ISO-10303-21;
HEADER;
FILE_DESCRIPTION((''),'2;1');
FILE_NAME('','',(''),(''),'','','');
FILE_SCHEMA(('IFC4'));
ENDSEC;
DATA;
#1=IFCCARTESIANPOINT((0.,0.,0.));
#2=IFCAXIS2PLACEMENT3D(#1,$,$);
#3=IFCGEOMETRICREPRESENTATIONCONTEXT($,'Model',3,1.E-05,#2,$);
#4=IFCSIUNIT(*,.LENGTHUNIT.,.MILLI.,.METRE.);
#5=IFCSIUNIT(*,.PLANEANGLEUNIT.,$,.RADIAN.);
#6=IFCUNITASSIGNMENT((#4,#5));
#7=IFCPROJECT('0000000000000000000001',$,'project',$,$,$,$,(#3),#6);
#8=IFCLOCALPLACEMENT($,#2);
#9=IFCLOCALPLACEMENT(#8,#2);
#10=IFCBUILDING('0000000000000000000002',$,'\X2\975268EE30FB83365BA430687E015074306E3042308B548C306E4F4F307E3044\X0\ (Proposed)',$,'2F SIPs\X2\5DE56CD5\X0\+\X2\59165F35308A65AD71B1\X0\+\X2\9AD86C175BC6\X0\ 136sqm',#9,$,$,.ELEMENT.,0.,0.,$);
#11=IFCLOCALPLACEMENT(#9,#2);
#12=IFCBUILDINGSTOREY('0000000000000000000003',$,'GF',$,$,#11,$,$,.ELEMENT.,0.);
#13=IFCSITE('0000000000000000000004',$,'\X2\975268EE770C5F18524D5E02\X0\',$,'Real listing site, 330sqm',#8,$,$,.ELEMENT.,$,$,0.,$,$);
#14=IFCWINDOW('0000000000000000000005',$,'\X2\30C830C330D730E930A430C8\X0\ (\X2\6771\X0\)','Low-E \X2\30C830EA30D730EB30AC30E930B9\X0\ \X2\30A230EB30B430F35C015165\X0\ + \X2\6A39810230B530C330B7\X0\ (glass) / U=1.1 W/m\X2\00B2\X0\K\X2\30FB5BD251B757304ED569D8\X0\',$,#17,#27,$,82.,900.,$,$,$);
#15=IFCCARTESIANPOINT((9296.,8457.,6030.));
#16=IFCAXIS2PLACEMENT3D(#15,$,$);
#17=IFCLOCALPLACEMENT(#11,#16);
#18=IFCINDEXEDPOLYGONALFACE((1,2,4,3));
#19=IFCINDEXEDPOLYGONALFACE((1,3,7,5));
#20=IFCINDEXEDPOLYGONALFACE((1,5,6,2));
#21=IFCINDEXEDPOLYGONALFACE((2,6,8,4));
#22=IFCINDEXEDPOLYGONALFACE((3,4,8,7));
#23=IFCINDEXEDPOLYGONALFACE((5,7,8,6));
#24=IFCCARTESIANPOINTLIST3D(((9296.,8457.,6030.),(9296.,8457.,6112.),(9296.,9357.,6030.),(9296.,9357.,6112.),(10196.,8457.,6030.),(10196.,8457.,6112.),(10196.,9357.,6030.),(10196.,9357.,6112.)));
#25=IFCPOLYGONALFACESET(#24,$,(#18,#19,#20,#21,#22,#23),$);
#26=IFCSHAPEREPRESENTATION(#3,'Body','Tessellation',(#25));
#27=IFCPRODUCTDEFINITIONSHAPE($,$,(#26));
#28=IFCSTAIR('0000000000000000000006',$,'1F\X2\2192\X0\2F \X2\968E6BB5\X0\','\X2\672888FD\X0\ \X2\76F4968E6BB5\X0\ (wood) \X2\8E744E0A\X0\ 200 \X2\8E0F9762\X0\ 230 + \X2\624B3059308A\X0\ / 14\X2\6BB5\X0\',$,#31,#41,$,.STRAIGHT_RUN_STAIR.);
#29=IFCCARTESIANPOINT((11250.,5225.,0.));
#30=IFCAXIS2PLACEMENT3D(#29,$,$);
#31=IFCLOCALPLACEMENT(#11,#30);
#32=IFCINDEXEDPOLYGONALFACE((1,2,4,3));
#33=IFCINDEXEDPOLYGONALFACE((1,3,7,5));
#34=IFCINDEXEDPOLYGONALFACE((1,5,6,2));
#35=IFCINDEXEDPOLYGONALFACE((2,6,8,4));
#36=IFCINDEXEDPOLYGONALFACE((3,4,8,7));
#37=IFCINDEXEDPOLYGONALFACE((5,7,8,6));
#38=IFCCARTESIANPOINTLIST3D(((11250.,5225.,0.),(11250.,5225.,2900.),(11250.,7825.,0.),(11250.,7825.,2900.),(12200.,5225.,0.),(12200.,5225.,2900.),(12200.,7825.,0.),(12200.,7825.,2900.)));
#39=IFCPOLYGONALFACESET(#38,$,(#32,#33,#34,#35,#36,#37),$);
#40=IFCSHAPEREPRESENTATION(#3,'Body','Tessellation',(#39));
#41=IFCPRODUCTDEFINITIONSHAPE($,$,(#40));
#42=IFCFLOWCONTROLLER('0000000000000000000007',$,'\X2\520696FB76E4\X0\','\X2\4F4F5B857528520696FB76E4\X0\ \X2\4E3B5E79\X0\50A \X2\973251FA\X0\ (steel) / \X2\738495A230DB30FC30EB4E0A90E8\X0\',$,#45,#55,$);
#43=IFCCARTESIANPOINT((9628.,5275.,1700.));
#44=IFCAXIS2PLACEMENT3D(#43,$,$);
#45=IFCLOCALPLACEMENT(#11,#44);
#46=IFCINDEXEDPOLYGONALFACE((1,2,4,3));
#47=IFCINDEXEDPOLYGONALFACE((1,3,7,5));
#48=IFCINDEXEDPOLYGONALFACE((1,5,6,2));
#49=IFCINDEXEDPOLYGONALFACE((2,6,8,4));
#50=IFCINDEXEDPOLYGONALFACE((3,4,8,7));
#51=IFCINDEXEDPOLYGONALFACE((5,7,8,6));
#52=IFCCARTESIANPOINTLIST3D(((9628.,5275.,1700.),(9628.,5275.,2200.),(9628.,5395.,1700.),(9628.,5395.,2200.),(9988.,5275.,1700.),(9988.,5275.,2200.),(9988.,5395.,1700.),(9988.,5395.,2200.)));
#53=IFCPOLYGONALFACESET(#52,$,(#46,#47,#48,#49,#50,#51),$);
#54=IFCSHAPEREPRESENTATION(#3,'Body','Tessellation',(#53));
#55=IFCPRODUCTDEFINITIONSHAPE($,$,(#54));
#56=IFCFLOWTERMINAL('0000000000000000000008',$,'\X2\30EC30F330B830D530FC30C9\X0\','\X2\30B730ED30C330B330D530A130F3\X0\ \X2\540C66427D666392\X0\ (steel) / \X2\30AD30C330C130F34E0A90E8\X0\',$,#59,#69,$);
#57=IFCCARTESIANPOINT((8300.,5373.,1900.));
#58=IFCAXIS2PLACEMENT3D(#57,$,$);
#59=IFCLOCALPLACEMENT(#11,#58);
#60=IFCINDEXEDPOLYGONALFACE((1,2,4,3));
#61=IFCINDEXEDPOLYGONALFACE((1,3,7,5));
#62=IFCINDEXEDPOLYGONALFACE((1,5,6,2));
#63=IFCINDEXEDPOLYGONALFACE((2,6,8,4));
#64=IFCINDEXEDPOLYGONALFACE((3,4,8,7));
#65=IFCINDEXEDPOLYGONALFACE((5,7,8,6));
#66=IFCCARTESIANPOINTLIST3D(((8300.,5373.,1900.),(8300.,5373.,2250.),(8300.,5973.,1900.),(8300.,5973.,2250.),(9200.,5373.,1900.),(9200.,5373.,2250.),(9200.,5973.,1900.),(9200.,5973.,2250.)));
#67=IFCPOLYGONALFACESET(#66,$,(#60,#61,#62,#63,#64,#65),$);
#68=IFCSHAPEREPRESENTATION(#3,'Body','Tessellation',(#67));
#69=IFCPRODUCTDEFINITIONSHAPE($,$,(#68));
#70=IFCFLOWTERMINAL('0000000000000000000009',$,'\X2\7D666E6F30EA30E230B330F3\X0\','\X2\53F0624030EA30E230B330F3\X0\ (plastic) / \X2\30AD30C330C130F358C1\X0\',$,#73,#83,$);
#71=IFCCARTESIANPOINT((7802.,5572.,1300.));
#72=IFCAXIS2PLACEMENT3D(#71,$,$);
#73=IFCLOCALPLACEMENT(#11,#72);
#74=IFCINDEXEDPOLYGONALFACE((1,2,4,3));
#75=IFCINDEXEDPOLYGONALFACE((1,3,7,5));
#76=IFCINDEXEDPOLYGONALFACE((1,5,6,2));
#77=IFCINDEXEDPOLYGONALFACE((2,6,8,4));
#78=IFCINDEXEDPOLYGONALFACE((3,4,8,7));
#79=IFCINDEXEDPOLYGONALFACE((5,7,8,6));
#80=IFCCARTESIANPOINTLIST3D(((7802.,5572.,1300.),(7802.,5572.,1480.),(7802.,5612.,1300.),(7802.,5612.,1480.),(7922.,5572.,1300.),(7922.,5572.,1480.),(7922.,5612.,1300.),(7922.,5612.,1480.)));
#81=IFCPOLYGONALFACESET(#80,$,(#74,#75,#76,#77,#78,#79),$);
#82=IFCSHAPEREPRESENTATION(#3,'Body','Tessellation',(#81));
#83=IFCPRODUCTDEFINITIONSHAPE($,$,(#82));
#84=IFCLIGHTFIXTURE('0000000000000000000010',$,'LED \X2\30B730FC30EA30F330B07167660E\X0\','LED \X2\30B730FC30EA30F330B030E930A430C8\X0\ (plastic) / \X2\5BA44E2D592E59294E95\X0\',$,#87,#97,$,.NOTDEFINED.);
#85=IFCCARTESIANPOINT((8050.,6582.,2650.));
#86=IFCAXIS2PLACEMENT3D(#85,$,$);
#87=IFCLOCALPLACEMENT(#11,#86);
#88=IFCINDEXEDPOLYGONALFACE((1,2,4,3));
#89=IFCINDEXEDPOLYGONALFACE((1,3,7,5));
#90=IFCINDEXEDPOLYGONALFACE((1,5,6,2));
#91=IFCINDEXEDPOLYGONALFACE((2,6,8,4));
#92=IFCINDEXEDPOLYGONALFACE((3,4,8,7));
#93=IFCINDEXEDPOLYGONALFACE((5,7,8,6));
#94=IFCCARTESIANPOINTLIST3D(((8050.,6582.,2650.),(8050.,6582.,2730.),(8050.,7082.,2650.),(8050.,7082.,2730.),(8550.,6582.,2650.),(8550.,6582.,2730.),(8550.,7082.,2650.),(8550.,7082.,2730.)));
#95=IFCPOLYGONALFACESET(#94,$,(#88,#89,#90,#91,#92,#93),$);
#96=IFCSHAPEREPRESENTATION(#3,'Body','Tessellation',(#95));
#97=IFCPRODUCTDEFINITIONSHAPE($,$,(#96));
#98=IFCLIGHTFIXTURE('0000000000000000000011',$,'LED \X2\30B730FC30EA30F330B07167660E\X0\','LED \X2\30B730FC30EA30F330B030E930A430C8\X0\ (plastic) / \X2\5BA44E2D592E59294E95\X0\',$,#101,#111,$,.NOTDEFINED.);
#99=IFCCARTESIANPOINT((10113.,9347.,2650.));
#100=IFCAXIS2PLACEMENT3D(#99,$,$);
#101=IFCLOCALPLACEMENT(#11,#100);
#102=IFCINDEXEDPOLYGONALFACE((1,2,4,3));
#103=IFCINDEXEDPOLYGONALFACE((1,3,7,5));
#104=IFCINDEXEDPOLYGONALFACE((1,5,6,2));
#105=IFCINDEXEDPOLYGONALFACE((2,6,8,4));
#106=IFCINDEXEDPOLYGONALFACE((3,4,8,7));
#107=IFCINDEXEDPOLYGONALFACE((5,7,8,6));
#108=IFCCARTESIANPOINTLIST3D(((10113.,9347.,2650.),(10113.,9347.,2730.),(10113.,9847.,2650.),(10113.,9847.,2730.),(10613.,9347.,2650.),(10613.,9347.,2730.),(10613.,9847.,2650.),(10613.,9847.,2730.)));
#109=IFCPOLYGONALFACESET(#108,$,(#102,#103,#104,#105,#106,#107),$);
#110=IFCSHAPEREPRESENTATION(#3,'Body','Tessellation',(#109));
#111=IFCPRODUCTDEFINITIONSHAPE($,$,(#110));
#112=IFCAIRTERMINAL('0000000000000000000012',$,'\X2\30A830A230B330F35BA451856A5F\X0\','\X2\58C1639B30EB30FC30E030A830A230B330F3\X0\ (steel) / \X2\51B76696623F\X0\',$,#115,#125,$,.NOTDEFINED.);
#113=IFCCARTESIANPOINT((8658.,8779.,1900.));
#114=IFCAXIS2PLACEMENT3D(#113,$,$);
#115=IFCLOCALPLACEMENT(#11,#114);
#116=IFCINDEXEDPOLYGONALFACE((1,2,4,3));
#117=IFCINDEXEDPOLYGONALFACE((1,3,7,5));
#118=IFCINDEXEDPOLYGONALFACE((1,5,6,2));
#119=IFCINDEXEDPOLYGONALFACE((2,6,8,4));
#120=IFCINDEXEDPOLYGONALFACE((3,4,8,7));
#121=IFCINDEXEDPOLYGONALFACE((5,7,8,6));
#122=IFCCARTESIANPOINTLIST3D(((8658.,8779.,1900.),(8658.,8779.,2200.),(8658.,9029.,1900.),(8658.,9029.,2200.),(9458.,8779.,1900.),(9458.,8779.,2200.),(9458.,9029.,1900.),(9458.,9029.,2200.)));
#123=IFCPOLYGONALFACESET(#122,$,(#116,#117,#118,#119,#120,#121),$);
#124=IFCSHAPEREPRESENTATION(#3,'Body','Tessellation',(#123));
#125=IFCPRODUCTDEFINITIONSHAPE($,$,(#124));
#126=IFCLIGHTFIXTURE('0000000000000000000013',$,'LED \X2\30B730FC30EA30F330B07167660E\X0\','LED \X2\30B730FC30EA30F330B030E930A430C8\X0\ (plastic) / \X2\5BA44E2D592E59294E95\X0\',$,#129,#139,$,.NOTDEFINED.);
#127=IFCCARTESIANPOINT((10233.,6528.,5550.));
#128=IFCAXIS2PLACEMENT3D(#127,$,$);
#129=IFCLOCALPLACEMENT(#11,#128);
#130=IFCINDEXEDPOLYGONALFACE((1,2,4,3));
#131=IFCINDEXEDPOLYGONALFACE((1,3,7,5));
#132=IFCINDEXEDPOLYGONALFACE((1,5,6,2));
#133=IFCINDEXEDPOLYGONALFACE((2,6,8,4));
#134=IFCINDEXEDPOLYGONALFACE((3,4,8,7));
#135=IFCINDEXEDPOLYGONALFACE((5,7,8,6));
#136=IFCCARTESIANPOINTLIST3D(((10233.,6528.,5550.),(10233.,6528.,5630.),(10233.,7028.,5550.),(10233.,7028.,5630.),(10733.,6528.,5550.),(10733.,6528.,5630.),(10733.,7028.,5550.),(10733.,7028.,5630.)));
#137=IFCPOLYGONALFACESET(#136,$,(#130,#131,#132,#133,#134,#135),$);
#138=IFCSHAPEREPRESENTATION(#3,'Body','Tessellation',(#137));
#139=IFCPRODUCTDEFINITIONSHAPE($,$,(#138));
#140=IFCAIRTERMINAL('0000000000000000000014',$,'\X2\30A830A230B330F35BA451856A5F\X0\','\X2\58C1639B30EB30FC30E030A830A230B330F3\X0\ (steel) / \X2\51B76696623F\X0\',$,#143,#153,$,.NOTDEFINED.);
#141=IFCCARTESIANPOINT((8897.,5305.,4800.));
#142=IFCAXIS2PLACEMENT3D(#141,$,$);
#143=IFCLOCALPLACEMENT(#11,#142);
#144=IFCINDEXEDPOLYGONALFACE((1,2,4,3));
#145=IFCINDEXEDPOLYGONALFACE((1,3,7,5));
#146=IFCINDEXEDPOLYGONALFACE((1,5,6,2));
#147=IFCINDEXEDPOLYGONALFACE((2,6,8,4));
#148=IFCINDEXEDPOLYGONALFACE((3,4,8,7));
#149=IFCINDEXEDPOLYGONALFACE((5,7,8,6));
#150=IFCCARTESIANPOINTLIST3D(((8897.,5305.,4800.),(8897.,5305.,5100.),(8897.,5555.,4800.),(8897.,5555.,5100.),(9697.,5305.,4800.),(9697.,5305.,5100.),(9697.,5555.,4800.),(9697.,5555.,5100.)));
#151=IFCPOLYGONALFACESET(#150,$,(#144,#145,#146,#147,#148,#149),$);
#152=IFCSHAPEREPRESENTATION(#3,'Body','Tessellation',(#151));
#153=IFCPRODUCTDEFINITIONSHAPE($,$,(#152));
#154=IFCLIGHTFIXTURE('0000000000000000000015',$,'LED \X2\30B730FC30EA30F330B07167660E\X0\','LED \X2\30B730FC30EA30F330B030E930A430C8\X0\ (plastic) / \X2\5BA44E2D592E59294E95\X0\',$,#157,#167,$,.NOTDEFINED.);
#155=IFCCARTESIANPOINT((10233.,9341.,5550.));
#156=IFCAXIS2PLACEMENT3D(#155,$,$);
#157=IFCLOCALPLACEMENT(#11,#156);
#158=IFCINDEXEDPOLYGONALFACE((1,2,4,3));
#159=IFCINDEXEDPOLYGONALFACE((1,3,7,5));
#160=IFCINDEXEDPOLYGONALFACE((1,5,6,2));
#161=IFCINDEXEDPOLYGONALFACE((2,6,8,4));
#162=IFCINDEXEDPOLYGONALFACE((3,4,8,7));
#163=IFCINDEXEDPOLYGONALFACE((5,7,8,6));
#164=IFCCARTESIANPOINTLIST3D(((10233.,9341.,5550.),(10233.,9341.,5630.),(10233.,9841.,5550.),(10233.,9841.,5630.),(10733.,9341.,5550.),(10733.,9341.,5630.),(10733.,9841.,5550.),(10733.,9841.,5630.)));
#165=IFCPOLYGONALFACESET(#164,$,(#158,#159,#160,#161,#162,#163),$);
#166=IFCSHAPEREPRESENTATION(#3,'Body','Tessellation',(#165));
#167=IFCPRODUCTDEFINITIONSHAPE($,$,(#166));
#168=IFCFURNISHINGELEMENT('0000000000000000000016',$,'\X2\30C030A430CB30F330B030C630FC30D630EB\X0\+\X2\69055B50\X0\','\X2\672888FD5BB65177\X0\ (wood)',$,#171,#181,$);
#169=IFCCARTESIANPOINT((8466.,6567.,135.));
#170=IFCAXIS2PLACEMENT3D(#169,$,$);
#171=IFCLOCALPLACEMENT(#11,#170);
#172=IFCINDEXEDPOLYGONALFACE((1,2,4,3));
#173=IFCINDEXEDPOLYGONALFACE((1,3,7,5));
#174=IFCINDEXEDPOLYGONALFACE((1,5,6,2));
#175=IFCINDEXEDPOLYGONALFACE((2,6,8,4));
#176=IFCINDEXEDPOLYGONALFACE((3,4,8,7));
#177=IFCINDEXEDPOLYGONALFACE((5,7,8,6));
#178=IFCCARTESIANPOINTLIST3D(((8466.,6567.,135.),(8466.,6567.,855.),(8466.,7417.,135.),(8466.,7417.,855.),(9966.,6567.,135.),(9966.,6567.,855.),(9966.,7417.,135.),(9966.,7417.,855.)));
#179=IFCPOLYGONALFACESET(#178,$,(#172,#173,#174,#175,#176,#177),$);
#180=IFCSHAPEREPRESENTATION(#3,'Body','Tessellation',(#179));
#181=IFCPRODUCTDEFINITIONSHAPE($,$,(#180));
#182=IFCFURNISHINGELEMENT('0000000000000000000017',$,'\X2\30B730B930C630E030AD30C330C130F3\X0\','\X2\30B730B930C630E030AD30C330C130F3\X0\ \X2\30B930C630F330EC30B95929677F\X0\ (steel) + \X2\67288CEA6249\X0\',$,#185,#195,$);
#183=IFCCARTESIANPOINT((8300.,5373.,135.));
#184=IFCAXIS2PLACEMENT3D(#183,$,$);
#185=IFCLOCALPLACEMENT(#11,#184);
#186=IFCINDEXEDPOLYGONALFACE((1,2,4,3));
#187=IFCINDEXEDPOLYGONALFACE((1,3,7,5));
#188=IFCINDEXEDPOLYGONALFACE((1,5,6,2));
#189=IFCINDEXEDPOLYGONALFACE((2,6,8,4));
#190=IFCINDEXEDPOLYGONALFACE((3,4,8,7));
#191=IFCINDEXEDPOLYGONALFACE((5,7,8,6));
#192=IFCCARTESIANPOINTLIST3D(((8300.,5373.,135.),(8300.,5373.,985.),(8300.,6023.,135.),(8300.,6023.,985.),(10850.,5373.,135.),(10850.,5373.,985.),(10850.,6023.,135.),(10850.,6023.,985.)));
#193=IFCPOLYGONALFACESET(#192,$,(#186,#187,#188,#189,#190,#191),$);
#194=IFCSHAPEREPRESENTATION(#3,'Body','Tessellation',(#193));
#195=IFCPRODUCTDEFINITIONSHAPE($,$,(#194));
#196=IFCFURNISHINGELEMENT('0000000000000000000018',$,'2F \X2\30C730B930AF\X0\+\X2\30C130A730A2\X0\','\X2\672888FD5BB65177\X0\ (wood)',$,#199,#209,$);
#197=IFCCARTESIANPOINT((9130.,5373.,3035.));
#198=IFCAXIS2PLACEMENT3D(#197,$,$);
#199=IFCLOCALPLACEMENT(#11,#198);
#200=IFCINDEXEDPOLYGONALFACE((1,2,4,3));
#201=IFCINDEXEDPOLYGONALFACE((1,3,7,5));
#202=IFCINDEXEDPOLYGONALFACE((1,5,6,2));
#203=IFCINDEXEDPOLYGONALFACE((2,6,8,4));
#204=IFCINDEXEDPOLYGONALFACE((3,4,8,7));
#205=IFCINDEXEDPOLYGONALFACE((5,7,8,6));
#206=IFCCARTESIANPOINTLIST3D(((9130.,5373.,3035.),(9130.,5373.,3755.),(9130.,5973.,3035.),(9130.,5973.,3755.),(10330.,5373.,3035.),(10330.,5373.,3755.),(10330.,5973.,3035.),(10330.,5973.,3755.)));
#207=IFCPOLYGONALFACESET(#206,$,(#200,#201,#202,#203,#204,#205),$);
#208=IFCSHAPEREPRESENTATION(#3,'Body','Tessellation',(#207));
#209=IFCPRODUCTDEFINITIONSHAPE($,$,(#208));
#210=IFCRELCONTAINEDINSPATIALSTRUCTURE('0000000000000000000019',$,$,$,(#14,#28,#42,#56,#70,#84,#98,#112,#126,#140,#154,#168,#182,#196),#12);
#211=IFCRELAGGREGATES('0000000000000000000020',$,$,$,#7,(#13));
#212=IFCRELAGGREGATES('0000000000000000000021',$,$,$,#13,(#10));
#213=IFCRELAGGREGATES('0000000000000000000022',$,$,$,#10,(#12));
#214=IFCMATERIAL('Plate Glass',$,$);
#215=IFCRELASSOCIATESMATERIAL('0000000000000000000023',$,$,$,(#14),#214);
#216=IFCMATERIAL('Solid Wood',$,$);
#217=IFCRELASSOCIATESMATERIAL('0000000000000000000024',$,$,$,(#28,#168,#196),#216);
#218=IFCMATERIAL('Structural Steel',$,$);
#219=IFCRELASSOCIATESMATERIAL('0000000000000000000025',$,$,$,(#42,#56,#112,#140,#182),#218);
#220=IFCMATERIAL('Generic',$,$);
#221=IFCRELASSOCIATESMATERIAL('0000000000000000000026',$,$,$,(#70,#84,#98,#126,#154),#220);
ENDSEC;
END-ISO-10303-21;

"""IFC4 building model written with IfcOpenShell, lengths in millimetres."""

from ifc_helpers import new_model, si_unit, frame, frame_2d, origin, place, context, project, spatial, rectangle, extrude, material, element, save


model = new_model("IFC4")

# Units and contexts
model_context = context("Model", 3, precision=1e-05, world=origin())
ifc_project = project(units=[si_unit("LENGTHUNIT", "METRE", prefix="MILLI"), si_unit("PLANEANGLEUNIT", "RADIAN")], contexts=[model_context])

# Site, building, storey
site_placement = place(None, origin())
site = spatial("IfcSite", under=ifc_project, at=site_placement, Name="青森県弘前市", ObjectType="Real listing site, 330sqm", CompositionType="ELEMENT", RefElevation=0.0)
building_placement = place(site_placement, origin())
building = spatial("IfcBuilding", under=site, at=building_placement, Name="青森・茶室と縁側のある和の住まい (Proposed)", ObjectType="2F SIPs工法+外張り断熱+高気密 136sqm", CompositionType="ELEMENT", ElevationOfRefHeight=0.0, ElevationOfTerrain=0.0)
storey_placement = place(building_placement, origin())
storey = spatial("IfcBuildingStorey", under=building, at=storey_placement, Name="GF", CompositionType="ELEMENT", Elevation=0.0)

# Shared definitions
ifc_material_1 = material(Name="Solid Wood")

# Window
ifc_material_2 = material(Name="Plate Glass")
window_placement = place(storey_placement, frame((9296.0, 8457.0, 6030.0)))
element("IfcWindow", 1, at=window_placement, inside=storey, material=ifc_material_2, Name="トップライト (東)", Description="Low-E トリプルガラス アルゴン封入 + 樹脂サッシ (glass) / U=1.1 W/m²K・寒冷地仕様", OverallHeight=82.0, OverallWidth=900.0, context=model_context, shape_type="SweptSolid", body=[
    extrude(rectangle(XDim=900.0, YDim=900.0, at=frame_2d((450.0, 450.0))), frame((9296.0, 8457.0, 6030.0)), (0.0, 0.0, 1.0), 82.0),
])

# Stair
stair_placement = place(storey_placement, frame((11250.0, 5225.0, 0.0)))
element("IfcStair", 2, at=stair_placement, inside=storey, material=ifc_material_1, Name="1F→2F 階段", Description="木製 直階段 (wood) 蹴上 200 踏面 230 + 手すり / 14段", PredefinedType="STRAIGHT_RUN_STAIR", context=model_context, shape_type="SweptSolid", body=[
    extrude(rectangle(XDim=950.0, YDim=2600.0, at=frame_2d((475.0, 1300.0))), frame((11250.0, 5225.0, 0.0)), (0.0, 0.0, 1.0), 2900.0),
])

# Flow controller
ifc_material_3 = material(Name="Structural Steel")
flow_controller_placement = place(storey_placement, frame((9628.0, 5275.0, 1700.0)))
element("IfcFlowController", 3, at=flow_controller_placement, inside=storey, material=ifc_material_3, Name="分電盤", Description="住宅用分電盤 主幹50A 露出 (steel) / 玄関ホール上部", context=model_context, shape_type="SweptSolid", body=[
    extrude(rectangle(XDim=360.0, YDim=120.0, at=frame_2d((180.0, 60.0))), frame((9628.0, 5275.0, 1700.0)), (0.0, 0.0, 1.0), 500.0),
])

# Flow terminals
flow_terminal_1_placement = place(storey_placement, frame((8300.0, 5373.0, 1900.0)))
element("IfcFlowTerminal", 4, at=flow_terminal_1_placement, inside=storey, material=ifc_material_3, Name="レンジフード", Description="シロッコファン 同時給排 (steel) / キッチン上部", context=model_context, shape_type="SweptSolid", body=[
    extrude(rectangle(XDim=900.0, YDim=600.0, at=frame_2d((450.0, 300.0))), frame((8300.0, 5373.0, 1900.0)), (0.0, 0.0, 1.0), 350.0),
])
ifc_material_4 = material(Name="Generic")
flow_terminal_2_placement = place(storey_placement, frame((7802.0, 5572.0, 1300.0)))
element("IfcFlowTerminal", 5, at=flow_terminal_2_placement, inside=storey, material=ifc_material_4, Name="給湯リモコン", Description="台所リモコン (plastic) / キッチン壁", context=model_context, shape_type="SweptSolid", body=[
    extrude(rectangle(XDim=120.0, YDim=40.0, at=frame_2d((60.0, 20.0))), frame((7802.0, 5572.0, 1300.0)), (0.0, 0.0, 1.0), 180.0),
])

# Light fixtures
light_fixture_1_placement = place(storey_placement, frame((8050.0, 6582.0, 2650.0)))
element("IfcLightFixture", 6, at=light_fixture_1_placement, inside=storey, material=ifc_material_4, Name="LED シーリング照明", Description="LED シーリングライト (plastic) / 室中央天井", PredefinedType="NOTDEFINED", context=model_context, shape_type="SweptSolid", body=[
    extrude(rectangle(XDim=500.0, YDim=500.0, at=frame_2d((250.0, 250.0))), frame((8050.0, 6582.0, 2650.0)), (0.0, 0.0, 1.0), 80.0),
])
light_fixture_2_placement = place(storey_placement, frame((10113.0, 9347.0, 2650.0)))
element("IfcLightFixture", 7, at=light_fixture_2_placement, inside=storey, material=ifc_material_4, Name="LED シーリング照明", Description="LED シーリングライト (plastic) / 室中央天井", PredefinedType="NOTDEFINED", context=model_context, shape_type="SweptSolid", body=[
    extrude(rectangle(XDim=500.0, YDim=500.0, at=frame_2d((250.0, 250.0))), frame((10113.0, 9347.0, 2650.0)), (0.0, 0.0, 1.0), 80.0),
])

# Air terminal
air_terminal_1_placement = place(storey_placement, frame((8658.0, 8779.0, 1900.0)))
element("IfcAirTerminal", 8, at=air_terminal_1_placement, inside=storey, material=ifc_material_3, Name="エアコン室内機", Description="壁掛ルームエアコン (steel) / 冷暖房", PredefinedType="NOTDEFINED", context=model_context, shape_type="SweptSolid", body=[
    extrude(rectangle(XDim=800.0, YDim=250.0, at=frame_2d((400.0, 125.0))), frame((8658.0, 8779.0, 1900.0)), (0.0, 0.0, 1.0), 300.0),
])

# Light fixture
light_fixture_3_placement = place(storey_placement, frame((10233.0, 6528.0, 5550.0)))
element("IfcLightFixture", 9, at=light_fixture_3_placement, inside=storey, material=ifc_material_4, Name="LED シーリング照明", Description="LED シーリングライト (plastic) / 室中央天井", PredefinedType="NOTDEFINED", context=model_context, shape_type="SweptSolid", body=[
    extrude(rectangle(XDim=500.0, YDim=500.0, at=frame_2d((250.0, 250.0))), frame((10233.0, 6528.0, 5550.0)), (0.0, 0.0, 1.0), 80.0),
])

# Air terminal
air_terminal_2_placement = place(storey_placement, frame((8897.0, 5305.0, 4800.0)))
element("IfcAirTerminal", 10, at=air_terminal_2_placement, inside=storey, material=ifc_material_3, Name="エアコン室内機", Description="壁掛ルームエアコン (steel) / 冷暖房", PredefinedType="NOTDEFINED", context=model_context, shape_type="SweptSolid", body=[
    extrude(rectangle(XDim=800.0, YDim=250.0, at=frame_2d((400.0, 125.0))), frame((8897.0, 5305.0, 4800.0)), (0.0, 0.0, 1.0), 300.0),
])

# Light fixture
light_fixture_4_placement = place(storey_placement, frame((10233.0, 9341.0, 5550.0)))
element("IfcLightFixture", 11, at=light_fixture_4_placement, inside=storey, material=ifc_material_4, Name="LED シーリング照明", Description="LED シーリングライト (plastic) / 室中央天井", PredefinedType="NOTDEFINED", context=model_context, shape_type="SweptSolid", body=[
    extrude(rectangle(XDim=500.0, YDim=500.0, at=frame_2d((250.0, 250.0))), frame((10233.0, 9341.0, 5550.0)), (0.0, 0.0, 1.0), 80.0),
])

# Furnishing elements
furnishing_1_placement = place(storey_placement, frame((8466.0, 6567.0, 135.0)))
element("IfcFurnishingElement", 12, at=furnishing_1_placement, inside=storey, material=ifc_material_1, Name="ダイニングテーブル+椅子", Description="木製家具 (wood)", context=model_context, shape_type="SweptSolid", body=[
    extrude(rectangle(XDim=1500.0, YDim=850.0, at=frame_2d((750.0, 425.0))), frame((8466.0, 6567.0, 135.0)), (0.0, 0.0, 1.0), 720.0),
])
furnishing_2_placement = place(storey_placement, frame((8300.0, 5373.0, 135.0)))
element("IfcFurnishingElement", 13, at=furnishing_2_placement, inside=storey, material=ifc_material_3, Name="システムキッチン", Description="システムキッチン ステンレス天板 (steel) + 木質扉", context=model_context, shape_type="SweptSolid", body=[
    extrude(rectangle(XDim=2550.0, YDim=650.0, at=frame_2d((1275.0, 325.0))), frame((8300.0, 5373.0, 135.0)), (0.0, 0.0, 1.0), 850.0),
])
furnishing_3_placement = place(storey_placement, frame((9130.0, 5373.0, 3035.0)))
element("IfcFurnishingElement", 14, at=furnishing_3_placement, inside=storey, material=ifc_material_1, Name="2F デスク+チェア", Description="木製家具 (wood)", context=model_context, shape_type="SweptSolid", body=[
    extrude(rectangle(XDim=1200.0, YDim=600.0, at=frame_2d((600.0, 300.0))), frame((9130.0, 5373.0, 3035.0)), (0.0, 0.0, 1.0), 720.0),
])

save(model, "model.ifc")
